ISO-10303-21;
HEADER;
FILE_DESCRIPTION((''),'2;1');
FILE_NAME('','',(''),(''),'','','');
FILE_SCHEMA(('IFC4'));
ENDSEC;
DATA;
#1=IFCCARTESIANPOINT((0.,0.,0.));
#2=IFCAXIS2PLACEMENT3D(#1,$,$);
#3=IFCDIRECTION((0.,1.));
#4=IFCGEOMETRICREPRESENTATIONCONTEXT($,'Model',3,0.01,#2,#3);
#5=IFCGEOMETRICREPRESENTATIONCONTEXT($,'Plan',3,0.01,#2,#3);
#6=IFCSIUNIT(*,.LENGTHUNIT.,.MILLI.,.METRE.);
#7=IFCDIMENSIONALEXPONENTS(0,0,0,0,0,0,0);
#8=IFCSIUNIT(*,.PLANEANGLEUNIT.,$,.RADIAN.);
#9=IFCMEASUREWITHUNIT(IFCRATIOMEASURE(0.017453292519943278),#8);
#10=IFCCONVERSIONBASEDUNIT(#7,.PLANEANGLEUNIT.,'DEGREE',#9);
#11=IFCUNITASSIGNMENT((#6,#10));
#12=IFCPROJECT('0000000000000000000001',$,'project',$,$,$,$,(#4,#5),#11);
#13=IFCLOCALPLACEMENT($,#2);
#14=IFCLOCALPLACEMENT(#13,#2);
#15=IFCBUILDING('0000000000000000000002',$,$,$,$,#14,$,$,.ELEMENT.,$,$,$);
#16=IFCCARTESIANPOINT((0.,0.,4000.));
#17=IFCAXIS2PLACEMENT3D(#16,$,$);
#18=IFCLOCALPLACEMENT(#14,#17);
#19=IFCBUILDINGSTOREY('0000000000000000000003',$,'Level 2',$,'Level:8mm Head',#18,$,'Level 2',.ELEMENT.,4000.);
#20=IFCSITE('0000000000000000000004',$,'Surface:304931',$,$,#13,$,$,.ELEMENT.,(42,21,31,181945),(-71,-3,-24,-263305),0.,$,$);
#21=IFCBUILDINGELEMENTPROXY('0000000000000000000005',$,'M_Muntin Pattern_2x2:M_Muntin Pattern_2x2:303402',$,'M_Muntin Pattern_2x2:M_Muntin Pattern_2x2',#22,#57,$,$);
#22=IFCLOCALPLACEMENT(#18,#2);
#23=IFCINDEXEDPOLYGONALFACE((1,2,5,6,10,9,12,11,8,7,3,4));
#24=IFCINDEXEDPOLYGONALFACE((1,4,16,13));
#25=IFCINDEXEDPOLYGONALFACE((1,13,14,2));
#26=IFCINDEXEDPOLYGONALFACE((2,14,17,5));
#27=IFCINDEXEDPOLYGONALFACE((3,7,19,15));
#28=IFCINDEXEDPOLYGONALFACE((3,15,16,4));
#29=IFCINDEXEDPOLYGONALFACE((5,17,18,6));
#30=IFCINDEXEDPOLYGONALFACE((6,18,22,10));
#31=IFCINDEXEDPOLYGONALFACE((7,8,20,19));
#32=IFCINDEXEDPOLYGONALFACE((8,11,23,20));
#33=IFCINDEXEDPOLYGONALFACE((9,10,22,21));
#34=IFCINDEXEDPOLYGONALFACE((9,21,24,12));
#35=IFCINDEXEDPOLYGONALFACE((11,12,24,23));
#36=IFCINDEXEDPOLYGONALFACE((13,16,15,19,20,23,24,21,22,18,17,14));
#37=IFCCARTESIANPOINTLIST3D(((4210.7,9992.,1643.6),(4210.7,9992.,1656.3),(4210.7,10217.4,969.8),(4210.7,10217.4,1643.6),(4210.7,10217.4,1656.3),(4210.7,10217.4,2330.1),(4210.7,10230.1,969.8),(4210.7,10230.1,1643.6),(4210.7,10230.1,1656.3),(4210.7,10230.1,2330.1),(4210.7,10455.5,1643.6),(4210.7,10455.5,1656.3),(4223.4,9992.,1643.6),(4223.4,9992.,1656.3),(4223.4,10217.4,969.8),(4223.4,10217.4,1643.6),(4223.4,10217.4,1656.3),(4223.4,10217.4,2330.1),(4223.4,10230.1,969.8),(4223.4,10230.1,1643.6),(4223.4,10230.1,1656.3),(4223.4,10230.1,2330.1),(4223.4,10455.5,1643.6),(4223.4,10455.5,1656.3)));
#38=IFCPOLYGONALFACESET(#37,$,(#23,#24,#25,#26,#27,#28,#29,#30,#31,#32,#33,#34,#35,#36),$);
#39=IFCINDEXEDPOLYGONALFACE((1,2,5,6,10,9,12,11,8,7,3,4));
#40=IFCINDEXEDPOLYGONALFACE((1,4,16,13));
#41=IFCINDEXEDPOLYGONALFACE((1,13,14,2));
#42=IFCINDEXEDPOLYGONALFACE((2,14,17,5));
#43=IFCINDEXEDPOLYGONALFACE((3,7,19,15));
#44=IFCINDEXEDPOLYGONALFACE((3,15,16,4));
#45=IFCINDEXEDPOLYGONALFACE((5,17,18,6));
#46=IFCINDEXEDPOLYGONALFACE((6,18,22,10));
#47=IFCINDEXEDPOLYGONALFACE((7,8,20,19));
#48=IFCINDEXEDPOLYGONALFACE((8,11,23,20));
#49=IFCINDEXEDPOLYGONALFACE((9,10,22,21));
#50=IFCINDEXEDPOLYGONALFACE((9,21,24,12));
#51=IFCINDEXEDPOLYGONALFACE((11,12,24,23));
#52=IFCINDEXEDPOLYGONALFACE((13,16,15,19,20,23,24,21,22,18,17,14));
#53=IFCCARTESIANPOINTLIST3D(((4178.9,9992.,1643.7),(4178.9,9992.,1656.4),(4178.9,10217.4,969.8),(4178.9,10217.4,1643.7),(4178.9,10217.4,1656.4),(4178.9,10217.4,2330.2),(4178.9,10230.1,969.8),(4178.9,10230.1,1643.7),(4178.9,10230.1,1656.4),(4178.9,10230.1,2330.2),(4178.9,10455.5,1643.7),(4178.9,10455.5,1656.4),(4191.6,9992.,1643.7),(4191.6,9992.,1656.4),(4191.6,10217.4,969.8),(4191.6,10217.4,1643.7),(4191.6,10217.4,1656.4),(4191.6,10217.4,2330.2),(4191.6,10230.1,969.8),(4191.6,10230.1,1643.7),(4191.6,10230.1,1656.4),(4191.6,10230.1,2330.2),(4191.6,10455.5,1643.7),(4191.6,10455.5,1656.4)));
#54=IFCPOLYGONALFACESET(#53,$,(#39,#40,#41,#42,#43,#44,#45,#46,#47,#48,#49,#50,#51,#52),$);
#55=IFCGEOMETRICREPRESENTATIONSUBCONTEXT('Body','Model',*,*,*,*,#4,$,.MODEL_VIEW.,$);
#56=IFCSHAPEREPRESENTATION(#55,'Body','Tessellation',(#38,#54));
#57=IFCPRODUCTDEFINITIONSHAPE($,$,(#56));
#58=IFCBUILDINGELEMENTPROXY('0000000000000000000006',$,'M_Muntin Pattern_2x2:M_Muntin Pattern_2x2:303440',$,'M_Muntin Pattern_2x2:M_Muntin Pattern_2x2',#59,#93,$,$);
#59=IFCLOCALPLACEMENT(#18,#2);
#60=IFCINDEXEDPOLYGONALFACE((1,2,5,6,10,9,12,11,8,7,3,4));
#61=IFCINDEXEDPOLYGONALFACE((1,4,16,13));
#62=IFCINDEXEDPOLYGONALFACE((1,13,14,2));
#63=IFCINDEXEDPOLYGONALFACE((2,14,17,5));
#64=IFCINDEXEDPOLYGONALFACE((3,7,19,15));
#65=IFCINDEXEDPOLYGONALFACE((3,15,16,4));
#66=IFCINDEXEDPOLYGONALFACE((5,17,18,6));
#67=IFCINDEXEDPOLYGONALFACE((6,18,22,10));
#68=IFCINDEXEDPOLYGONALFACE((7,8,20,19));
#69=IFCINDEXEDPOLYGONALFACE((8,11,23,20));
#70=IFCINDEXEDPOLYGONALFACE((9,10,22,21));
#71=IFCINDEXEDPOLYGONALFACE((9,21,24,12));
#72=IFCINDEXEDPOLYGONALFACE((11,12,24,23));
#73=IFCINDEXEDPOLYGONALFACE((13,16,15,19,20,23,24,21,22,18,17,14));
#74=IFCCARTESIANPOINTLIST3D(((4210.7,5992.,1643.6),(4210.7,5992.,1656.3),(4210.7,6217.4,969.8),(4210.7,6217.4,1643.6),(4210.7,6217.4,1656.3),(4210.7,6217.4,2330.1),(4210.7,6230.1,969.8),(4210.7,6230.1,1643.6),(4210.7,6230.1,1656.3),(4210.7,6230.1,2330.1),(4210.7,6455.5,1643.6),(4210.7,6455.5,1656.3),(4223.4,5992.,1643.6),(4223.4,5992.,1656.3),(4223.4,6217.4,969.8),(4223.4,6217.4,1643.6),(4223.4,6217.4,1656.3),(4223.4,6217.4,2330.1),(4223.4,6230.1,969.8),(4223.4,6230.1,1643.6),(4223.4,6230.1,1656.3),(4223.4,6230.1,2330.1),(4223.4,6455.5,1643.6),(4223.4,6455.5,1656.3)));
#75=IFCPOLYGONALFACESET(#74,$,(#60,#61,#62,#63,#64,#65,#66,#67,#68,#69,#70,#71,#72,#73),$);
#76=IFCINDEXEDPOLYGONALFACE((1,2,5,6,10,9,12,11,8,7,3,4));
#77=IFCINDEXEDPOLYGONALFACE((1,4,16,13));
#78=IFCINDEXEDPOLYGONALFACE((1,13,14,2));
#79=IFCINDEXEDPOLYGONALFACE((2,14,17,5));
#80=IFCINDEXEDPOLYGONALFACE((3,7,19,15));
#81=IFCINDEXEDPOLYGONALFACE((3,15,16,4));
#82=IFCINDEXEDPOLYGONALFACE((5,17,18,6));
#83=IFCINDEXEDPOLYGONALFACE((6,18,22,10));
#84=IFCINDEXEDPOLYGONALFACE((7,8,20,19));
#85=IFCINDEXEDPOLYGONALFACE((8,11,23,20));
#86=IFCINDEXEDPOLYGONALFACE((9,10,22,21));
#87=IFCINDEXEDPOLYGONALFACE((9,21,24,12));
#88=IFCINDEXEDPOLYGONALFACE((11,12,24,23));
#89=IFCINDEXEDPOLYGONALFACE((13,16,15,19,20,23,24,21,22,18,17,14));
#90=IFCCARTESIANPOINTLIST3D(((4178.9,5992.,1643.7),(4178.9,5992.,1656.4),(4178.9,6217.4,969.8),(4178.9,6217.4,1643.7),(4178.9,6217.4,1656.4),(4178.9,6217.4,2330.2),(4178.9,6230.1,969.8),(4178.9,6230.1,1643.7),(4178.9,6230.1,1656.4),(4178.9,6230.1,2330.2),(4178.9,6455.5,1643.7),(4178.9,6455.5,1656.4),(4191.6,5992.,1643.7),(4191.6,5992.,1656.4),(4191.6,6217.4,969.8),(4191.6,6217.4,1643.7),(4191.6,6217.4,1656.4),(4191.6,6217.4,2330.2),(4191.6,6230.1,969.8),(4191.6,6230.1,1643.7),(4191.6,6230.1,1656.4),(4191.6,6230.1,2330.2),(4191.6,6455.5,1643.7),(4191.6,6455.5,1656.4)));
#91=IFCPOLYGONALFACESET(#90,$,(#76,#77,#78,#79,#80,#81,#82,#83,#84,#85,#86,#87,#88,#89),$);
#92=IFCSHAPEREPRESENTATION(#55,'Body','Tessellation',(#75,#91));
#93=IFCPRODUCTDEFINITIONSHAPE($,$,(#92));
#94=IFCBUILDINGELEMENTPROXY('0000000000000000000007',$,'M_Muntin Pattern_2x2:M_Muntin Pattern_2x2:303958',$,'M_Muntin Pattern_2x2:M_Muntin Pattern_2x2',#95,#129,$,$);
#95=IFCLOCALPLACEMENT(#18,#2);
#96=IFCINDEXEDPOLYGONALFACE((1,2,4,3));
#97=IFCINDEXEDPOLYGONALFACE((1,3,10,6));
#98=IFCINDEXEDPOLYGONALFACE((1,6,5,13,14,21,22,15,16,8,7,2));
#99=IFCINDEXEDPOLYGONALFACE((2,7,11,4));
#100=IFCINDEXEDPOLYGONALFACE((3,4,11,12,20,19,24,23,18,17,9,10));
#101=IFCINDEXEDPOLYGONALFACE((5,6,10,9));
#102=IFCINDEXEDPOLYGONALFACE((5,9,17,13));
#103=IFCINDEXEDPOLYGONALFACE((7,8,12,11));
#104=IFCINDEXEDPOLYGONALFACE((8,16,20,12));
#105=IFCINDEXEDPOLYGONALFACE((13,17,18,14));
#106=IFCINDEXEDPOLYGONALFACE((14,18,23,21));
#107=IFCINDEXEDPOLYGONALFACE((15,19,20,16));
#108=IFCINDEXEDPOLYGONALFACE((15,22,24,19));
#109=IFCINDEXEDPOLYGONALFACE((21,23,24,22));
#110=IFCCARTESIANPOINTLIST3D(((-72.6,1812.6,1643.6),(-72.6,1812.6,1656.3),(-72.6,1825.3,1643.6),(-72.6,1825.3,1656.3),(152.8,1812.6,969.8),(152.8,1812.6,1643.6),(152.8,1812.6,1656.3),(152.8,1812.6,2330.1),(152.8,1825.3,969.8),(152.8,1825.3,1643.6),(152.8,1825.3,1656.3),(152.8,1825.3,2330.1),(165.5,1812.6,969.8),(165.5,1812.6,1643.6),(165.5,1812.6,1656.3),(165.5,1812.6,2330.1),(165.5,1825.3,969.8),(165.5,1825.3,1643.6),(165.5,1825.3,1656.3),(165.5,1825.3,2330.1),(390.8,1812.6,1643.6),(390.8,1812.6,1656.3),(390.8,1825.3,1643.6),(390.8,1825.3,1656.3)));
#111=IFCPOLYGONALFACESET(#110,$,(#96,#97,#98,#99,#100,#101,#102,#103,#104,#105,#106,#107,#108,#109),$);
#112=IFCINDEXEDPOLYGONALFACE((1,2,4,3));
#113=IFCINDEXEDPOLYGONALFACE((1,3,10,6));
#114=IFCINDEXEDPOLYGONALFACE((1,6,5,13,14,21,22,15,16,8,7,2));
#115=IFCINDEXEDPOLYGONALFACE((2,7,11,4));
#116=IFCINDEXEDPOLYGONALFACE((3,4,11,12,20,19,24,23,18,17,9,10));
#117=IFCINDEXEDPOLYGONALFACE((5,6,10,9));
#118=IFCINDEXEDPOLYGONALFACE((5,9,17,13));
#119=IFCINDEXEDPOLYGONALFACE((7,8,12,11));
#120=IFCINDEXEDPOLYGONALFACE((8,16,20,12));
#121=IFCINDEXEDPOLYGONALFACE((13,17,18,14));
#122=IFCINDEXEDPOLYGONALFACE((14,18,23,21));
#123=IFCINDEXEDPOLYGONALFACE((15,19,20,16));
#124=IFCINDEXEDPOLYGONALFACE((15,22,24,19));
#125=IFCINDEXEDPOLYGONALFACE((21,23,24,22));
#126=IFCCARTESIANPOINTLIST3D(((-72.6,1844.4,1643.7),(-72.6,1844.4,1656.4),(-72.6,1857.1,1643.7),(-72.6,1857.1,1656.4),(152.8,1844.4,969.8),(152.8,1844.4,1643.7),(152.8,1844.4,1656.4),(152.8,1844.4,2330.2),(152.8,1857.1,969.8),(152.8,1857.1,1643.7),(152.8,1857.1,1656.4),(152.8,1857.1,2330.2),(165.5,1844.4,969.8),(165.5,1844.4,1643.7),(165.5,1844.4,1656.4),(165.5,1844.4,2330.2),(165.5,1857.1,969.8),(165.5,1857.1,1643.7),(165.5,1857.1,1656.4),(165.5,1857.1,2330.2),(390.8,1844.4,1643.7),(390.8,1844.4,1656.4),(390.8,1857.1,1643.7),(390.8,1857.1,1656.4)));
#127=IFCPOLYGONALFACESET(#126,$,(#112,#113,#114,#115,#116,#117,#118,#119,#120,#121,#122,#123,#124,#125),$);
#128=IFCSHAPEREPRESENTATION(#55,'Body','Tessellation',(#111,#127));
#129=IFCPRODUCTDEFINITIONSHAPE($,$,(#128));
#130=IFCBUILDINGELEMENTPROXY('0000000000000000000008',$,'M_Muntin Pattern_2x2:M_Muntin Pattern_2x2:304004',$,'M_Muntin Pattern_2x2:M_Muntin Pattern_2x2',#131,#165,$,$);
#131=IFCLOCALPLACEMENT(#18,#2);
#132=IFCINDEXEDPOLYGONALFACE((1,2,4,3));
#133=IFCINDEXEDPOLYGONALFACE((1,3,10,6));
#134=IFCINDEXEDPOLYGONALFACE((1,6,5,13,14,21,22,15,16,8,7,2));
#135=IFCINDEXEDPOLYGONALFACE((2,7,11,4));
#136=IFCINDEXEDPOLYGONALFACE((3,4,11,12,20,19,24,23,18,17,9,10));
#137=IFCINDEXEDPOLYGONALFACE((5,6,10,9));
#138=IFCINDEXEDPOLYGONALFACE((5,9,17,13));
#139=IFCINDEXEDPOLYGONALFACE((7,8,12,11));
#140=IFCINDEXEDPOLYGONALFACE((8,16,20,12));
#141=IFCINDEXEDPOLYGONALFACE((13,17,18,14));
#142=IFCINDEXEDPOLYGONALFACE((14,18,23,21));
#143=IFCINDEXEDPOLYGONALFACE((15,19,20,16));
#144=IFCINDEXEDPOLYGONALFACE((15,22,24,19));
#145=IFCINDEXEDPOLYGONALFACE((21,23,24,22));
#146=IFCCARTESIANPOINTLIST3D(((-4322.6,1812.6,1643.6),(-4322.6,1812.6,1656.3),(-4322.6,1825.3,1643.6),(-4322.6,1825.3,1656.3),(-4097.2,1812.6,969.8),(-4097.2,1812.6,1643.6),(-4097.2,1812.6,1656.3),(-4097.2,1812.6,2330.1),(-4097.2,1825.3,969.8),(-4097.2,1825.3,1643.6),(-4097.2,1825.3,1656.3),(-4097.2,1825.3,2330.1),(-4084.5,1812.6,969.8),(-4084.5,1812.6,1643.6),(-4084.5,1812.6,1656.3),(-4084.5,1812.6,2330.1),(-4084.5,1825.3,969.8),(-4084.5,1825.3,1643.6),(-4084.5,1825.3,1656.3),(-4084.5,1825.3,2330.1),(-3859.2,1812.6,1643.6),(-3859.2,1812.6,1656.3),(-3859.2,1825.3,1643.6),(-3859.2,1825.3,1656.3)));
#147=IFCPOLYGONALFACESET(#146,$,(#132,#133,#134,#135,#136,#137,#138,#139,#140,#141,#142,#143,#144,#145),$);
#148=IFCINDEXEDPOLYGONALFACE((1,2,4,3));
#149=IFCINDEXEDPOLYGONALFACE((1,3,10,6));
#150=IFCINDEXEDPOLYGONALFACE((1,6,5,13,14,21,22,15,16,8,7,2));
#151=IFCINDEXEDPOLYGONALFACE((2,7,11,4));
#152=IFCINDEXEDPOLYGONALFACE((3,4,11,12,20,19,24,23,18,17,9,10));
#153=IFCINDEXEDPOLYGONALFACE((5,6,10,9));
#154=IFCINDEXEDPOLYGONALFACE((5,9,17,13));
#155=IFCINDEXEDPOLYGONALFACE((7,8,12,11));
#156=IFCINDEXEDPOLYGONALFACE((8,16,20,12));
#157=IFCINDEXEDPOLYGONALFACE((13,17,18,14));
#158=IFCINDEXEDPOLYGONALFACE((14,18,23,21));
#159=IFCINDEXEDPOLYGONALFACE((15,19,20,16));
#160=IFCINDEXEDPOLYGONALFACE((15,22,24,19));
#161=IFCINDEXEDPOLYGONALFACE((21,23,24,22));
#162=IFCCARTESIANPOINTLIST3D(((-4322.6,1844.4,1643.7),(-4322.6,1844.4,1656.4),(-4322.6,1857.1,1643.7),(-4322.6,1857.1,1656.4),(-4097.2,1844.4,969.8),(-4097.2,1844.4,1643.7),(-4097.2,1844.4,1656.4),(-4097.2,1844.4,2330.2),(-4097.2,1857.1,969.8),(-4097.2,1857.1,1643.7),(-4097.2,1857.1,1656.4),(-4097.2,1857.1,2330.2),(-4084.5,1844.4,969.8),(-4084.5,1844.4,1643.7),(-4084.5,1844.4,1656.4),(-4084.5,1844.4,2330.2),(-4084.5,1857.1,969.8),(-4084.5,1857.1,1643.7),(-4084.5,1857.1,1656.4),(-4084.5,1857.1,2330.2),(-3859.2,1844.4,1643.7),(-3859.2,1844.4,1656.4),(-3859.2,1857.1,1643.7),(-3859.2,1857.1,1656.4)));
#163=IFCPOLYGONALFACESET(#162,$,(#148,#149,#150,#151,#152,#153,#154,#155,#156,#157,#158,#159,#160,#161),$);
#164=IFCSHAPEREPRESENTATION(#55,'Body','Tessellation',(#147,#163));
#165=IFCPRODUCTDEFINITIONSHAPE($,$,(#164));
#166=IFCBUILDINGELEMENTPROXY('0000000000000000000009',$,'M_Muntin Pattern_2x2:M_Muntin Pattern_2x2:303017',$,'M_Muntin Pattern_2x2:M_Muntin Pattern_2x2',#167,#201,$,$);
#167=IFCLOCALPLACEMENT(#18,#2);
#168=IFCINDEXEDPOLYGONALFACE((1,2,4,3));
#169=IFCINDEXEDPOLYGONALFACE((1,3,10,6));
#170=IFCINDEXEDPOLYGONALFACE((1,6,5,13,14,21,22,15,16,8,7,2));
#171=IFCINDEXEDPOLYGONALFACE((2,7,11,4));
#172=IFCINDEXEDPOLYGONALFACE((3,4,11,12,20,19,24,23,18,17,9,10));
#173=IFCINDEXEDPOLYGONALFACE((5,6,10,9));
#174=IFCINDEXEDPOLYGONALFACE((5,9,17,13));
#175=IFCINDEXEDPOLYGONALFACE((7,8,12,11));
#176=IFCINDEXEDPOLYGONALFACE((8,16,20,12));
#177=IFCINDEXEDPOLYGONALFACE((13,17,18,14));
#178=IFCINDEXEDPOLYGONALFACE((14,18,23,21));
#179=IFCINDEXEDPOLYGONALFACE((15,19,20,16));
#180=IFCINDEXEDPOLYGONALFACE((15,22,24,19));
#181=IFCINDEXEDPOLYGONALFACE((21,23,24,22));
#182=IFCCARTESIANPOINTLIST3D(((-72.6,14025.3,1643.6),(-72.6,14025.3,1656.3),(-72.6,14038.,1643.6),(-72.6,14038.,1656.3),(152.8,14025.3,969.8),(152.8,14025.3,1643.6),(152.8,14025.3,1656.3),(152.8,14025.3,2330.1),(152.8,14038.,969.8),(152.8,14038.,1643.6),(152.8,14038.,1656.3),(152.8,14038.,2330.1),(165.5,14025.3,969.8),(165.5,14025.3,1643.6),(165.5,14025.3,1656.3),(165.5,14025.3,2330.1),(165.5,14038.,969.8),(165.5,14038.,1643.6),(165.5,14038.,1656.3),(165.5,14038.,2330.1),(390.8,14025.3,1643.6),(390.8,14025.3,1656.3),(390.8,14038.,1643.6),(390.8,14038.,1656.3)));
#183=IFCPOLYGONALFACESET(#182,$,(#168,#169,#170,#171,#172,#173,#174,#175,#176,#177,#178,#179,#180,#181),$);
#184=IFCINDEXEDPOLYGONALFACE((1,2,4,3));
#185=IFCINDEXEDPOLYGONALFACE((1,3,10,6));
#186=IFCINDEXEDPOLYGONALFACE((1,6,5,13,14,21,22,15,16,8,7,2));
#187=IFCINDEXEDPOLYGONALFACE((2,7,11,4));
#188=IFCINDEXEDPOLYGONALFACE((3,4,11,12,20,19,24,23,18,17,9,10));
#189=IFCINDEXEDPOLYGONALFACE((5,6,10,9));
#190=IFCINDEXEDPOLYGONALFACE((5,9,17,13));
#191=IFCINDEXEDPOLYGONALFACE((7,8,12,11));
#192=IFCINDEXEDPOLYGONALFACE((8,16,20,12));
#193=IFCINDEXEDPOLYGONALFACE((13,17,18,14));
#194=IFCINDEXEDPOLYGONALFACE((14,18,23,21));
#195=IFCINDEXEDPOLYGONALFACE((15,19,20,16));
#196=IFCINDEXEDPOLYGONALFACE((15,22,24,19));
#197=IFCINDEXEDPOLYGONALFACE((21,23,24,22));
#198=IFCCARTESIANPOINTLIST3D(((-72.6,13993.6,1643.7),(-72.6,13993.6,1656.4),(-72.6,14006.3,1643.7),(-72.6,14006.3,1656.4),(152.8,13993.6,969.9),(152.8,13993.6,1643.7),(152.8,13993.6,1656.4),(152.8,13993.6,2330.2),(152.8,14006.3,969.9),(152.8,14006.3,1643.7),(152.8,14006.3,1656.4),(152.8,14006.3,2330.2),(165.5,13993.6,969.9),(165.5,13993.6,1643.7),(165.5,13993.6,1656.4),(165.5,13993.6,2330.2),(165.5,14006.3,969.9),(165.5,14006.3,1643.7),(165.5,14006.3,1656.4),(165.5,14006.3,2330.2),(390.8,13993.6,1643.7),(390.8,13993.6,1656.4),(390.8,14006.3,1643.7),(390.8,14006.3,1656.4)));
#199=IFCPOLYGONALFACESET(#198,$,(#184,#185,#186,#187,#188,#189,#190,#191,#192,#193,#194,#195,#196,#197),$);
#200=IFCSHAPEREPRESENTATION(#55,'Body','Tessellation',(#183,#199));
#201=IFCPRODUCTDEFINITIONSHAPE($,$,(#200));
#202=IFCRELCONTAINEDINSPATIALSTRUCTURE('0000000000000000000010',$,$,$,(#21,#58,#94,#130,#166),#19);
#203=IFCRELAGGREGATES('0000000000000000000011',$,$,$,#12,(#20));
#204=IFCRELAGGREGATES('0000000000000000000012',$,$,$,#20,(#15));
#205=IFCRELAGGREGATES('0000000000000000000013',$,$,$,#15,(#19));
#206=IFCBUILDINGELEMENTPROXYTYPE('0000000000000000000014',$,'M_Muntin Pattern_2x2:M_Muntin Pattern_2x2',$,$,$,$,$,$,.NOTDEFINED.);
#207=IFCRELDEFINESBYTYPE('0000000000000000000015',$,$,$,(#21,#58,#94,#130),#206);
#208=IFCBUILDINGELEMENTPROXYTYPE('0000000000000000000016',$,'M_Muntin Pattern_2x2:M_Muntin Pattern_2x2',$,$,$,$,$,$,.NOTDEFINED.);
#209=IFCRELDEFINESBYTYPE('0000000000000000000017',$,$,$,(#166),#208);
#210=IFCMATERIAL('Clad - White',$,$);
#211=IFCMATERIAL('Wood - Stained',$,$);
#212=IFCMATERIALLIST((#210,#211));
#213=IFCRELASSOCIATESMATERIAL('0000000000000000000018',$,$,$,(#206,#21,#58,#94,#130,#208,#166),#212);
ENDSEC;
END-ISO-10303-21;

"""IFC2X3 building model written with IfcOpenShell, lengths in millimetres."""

from ifc_helpers import new_model, entity, si_unit, converted_unit, direction, frame, origin, place, context, subcontext, project, spatial, polyline, outline, extrude, source, transform, mapped, material, material_list, type_object, type_shapes, element, save


model = new_model("IFC2X3")

# Units and contexts
model_context = context("Model", 3, precision=0.01, world=origin(), true_north=direction((0.0, 1.0)))
plan_context = context("Plan", 3, precision=0.01, world=origin(), true_north=direction((0.0, 1.0)))
body_context = subcontext(model_context, "Body", "Model", "MODEL_VIEW")
ifc_project = project(units=[si_unit("LENGTHUNIT", "METRE", prefix="MILLI"), converted_unit("PLANEANGLEUNIT", "DEGREE", entity("IfcRatioMeasure", 0.017453292519943278), si_unit("PLANEANGLEUNIT", "RADIAN"), dimensions=[0, 0, 0, 0, 0, 0, 0])], contexts=[model_context, plan_context])

# Site, building, storey
site_placement = place(None, origin())
site = spatial("IfcSite", under=ifc_project, at=site_placement, Name="Surface:304931", CompositionType="ELEMENT", RefLatitude=(42, 21, 31, 181945), RefLongitude=(-71, -3, -24, -263305), RefElevation=0.0)
building_placement = place(site_placement, origin())
building = spatial("IfcBuilding", under=site, at=building_placement, CompositionType="ELEMENT")
storey_placement = place(building_placement, frame((0.0, 0.0, 4000.0)))
storey = spatial("IfcBuildingStorey", under=building, at=storey_placement, Name="Level 2", ObjectType="Level:8mm Head", LongName="Level 2", CompositionType="ELEMENT", Elevation=4000.0)

# Building element proxies
ifc_material_1 = material(Name="Clad - White")
ifc_material_2 = material(Name="Wood - Stained")
ifc_material_list = material_list([ifc_material_1, ifc_material_2])
building_element_proxy_type_1 = type_object("IfcBuildingElementProxyType", Name="M_Muntin Pattern_2x2:M_Muntin Pattern_2x2", PredefinedType="NOTDEFINED", material=ifc_material_list)
shared_shape_1 = source(origin(), body_context, "Body", "SweptSolid", [
    extrude(outline(polyline([(6.4, -6.4), (680.1, -6.4), (680.1, 6.3), (6.4, 6.3), (6.4, 231.7), (-6.3, 231.7), (-6.3, 6.3), (-680.2, 6.3), (-680.2, -6.4), (-6.3, -6.4), (-6.3, -231.7), (6.4, -231.7), (6.4, -6.4)])), frame((0.0, 9.5, 680.1), z_axis=(0.0, 1.0, 0.0), x_axis=(0.0, 0.0, 1.0)), (0.0, 0.0, 1.0), 12.7),
    extrude(outline(polyline([(6.4, -6.4), (680.2, -6.4), (680.2, 6.3), (6.4, 6.3), (6.4, 231.7), (-6.3, 231.7), (-6.3, 6.3), (-680.2, 6.3), (-680.2, -6.4), (-6.3, -6.4), (-6.3, -231.7), (6.4, -231.7), (6.4, -6.4)])), frame((0.0, -22.2, 680.2), z_axis=(0.0, 1.0, 0.0), x_axis=(0.0, 0.0, 1.0)), (0.0, 0.0, 1.0), 12.7),
])
type_shapes(building_element_proxy_type_1, [shared_shape_1])
for number, where, z_axis, x_axis, name in (
    (1, (4201.2, 10223.7, 969.8), (0.0, 0.0, 1.0), (0.0, -1.0, 0.0), "M_Muntin Pattern_2x2:M_Muntin Pattern_2x2:303402"),
    (2, (4201.2, 6223.7, 969.8), (0.0, 0.0, 1.0), (0.0, -1.0, 0.0), "M_Muntin Pattern_2x2:M_Muntin Pattern_2x2:303440"),
    (3, (159.1, 1834.8, 969.8), (0.0, 0.0, 1.0), (-1.0, 0.0, 0.0), "M_Muntin Pattern_2x2:M_Muntin Pattern_2x2:303958"),
    (4, (-4090.9, 1834.8, 969.8), (0.0, 0.0, 1.0), (-1.0, 0.0, 0.0), "M_Muntin Pattern_2x2:M_Muntin Pattern_2x2:304004"),
):
    element("IfcBuildingElementProxy", number, at=place(storey_placement, frame(where, z_axis=z_axis, x_axis=x_axis)), inside=storey, type_object=building_element_proxy_type_1, material=ifc_material_list, Name=name, ObjectType="M_Muntin Pattern_2x2:M_Muntin Pattern_2x2", context=body_context, shape_type="MappedRepresentation", body=[
        mapped(shared_shape_1, transform((0.0, 0.0, 0.0), scale=1.0)),
    ])
building_element_proxy_type_2 = type_object("IfcBuildingElementProxyType", Name="M_Muntin Pattern_2x2:M_Muntin Pattern_2x2", PredefinedType="NOTDEFINED", material=ifc_material_list)
shared_shape_2 = source(origin(), body_context, "Body", "SweptSolid", [
    extrude(outline(polyline([(6.4, -6.4), (680.1, -6.4), (680.1, 6.3), (6.4, 6.3), (6.4, 231.7), (-6.3, 231.7), (-6.3, 6.3), (-680.2, 6.3), (-680.2, -6.4), (-6.3, -6.4), (-6.3, -231.7), (6.4, -231.7), (6.4, -6.4)])), frame((0.0, -22.2, 680.1), z_axis=(0.0, 1.0, 0.0), x_axis=(0.0, 0.0, 1.0)), (0.0, 0.0, 1.0), 12.7),
    extrude(outline(polyline([(6.4, -6.4), (680.2, -6.4), (680.2, 6.3), (6.4, 6.3), (6.4, 231.7), (-6.3, 231.7), (-6.3, 6.3), (-680.2, 6.3), (-680.2, -6.4), (-6.3, -6.4), (-6.3, -231.7), (6.4, -231.7), (6.4, -6.4)])), frame((0.0, 9.5, 680.2), z_axis=(0.0, 1.0, 0.0), x_axis=(0.0, 0.0, 1.0)), (0.0, 0.0, 1.0), 12.7),
])
type_shapes(building_element_proxy_type_2, [shared_shape_2])
for number, where, z_axis, x_axis, name in (
    (5, (159.1, 14015.8, 969.9), (0.0, 0.0, 1.0), (-1.0, 0.0, 0.0), "M_Muntin Pattern_2x2:M_Muntin Pattern_2x2:303017"),
):
    element("IfcBuildingElementProxy", number, at=place(storey_placement, frame(where, z_axis=z_axis, x_axis=x_axis)), inside=storey, type_object=building_element_proxy_type_2, material=ifc_material_list, Name=name, ObjectType="M_Muntin Pattern_2x2:M_Muntin Pattern_2x2", context=body_context, shape_type="MappedRepresentation", body=[
        mapped(shared_shape_2, transform((0.0, 0.0, 0.0), scale=1.0)),
    ])

save(model, "model.ifc")
